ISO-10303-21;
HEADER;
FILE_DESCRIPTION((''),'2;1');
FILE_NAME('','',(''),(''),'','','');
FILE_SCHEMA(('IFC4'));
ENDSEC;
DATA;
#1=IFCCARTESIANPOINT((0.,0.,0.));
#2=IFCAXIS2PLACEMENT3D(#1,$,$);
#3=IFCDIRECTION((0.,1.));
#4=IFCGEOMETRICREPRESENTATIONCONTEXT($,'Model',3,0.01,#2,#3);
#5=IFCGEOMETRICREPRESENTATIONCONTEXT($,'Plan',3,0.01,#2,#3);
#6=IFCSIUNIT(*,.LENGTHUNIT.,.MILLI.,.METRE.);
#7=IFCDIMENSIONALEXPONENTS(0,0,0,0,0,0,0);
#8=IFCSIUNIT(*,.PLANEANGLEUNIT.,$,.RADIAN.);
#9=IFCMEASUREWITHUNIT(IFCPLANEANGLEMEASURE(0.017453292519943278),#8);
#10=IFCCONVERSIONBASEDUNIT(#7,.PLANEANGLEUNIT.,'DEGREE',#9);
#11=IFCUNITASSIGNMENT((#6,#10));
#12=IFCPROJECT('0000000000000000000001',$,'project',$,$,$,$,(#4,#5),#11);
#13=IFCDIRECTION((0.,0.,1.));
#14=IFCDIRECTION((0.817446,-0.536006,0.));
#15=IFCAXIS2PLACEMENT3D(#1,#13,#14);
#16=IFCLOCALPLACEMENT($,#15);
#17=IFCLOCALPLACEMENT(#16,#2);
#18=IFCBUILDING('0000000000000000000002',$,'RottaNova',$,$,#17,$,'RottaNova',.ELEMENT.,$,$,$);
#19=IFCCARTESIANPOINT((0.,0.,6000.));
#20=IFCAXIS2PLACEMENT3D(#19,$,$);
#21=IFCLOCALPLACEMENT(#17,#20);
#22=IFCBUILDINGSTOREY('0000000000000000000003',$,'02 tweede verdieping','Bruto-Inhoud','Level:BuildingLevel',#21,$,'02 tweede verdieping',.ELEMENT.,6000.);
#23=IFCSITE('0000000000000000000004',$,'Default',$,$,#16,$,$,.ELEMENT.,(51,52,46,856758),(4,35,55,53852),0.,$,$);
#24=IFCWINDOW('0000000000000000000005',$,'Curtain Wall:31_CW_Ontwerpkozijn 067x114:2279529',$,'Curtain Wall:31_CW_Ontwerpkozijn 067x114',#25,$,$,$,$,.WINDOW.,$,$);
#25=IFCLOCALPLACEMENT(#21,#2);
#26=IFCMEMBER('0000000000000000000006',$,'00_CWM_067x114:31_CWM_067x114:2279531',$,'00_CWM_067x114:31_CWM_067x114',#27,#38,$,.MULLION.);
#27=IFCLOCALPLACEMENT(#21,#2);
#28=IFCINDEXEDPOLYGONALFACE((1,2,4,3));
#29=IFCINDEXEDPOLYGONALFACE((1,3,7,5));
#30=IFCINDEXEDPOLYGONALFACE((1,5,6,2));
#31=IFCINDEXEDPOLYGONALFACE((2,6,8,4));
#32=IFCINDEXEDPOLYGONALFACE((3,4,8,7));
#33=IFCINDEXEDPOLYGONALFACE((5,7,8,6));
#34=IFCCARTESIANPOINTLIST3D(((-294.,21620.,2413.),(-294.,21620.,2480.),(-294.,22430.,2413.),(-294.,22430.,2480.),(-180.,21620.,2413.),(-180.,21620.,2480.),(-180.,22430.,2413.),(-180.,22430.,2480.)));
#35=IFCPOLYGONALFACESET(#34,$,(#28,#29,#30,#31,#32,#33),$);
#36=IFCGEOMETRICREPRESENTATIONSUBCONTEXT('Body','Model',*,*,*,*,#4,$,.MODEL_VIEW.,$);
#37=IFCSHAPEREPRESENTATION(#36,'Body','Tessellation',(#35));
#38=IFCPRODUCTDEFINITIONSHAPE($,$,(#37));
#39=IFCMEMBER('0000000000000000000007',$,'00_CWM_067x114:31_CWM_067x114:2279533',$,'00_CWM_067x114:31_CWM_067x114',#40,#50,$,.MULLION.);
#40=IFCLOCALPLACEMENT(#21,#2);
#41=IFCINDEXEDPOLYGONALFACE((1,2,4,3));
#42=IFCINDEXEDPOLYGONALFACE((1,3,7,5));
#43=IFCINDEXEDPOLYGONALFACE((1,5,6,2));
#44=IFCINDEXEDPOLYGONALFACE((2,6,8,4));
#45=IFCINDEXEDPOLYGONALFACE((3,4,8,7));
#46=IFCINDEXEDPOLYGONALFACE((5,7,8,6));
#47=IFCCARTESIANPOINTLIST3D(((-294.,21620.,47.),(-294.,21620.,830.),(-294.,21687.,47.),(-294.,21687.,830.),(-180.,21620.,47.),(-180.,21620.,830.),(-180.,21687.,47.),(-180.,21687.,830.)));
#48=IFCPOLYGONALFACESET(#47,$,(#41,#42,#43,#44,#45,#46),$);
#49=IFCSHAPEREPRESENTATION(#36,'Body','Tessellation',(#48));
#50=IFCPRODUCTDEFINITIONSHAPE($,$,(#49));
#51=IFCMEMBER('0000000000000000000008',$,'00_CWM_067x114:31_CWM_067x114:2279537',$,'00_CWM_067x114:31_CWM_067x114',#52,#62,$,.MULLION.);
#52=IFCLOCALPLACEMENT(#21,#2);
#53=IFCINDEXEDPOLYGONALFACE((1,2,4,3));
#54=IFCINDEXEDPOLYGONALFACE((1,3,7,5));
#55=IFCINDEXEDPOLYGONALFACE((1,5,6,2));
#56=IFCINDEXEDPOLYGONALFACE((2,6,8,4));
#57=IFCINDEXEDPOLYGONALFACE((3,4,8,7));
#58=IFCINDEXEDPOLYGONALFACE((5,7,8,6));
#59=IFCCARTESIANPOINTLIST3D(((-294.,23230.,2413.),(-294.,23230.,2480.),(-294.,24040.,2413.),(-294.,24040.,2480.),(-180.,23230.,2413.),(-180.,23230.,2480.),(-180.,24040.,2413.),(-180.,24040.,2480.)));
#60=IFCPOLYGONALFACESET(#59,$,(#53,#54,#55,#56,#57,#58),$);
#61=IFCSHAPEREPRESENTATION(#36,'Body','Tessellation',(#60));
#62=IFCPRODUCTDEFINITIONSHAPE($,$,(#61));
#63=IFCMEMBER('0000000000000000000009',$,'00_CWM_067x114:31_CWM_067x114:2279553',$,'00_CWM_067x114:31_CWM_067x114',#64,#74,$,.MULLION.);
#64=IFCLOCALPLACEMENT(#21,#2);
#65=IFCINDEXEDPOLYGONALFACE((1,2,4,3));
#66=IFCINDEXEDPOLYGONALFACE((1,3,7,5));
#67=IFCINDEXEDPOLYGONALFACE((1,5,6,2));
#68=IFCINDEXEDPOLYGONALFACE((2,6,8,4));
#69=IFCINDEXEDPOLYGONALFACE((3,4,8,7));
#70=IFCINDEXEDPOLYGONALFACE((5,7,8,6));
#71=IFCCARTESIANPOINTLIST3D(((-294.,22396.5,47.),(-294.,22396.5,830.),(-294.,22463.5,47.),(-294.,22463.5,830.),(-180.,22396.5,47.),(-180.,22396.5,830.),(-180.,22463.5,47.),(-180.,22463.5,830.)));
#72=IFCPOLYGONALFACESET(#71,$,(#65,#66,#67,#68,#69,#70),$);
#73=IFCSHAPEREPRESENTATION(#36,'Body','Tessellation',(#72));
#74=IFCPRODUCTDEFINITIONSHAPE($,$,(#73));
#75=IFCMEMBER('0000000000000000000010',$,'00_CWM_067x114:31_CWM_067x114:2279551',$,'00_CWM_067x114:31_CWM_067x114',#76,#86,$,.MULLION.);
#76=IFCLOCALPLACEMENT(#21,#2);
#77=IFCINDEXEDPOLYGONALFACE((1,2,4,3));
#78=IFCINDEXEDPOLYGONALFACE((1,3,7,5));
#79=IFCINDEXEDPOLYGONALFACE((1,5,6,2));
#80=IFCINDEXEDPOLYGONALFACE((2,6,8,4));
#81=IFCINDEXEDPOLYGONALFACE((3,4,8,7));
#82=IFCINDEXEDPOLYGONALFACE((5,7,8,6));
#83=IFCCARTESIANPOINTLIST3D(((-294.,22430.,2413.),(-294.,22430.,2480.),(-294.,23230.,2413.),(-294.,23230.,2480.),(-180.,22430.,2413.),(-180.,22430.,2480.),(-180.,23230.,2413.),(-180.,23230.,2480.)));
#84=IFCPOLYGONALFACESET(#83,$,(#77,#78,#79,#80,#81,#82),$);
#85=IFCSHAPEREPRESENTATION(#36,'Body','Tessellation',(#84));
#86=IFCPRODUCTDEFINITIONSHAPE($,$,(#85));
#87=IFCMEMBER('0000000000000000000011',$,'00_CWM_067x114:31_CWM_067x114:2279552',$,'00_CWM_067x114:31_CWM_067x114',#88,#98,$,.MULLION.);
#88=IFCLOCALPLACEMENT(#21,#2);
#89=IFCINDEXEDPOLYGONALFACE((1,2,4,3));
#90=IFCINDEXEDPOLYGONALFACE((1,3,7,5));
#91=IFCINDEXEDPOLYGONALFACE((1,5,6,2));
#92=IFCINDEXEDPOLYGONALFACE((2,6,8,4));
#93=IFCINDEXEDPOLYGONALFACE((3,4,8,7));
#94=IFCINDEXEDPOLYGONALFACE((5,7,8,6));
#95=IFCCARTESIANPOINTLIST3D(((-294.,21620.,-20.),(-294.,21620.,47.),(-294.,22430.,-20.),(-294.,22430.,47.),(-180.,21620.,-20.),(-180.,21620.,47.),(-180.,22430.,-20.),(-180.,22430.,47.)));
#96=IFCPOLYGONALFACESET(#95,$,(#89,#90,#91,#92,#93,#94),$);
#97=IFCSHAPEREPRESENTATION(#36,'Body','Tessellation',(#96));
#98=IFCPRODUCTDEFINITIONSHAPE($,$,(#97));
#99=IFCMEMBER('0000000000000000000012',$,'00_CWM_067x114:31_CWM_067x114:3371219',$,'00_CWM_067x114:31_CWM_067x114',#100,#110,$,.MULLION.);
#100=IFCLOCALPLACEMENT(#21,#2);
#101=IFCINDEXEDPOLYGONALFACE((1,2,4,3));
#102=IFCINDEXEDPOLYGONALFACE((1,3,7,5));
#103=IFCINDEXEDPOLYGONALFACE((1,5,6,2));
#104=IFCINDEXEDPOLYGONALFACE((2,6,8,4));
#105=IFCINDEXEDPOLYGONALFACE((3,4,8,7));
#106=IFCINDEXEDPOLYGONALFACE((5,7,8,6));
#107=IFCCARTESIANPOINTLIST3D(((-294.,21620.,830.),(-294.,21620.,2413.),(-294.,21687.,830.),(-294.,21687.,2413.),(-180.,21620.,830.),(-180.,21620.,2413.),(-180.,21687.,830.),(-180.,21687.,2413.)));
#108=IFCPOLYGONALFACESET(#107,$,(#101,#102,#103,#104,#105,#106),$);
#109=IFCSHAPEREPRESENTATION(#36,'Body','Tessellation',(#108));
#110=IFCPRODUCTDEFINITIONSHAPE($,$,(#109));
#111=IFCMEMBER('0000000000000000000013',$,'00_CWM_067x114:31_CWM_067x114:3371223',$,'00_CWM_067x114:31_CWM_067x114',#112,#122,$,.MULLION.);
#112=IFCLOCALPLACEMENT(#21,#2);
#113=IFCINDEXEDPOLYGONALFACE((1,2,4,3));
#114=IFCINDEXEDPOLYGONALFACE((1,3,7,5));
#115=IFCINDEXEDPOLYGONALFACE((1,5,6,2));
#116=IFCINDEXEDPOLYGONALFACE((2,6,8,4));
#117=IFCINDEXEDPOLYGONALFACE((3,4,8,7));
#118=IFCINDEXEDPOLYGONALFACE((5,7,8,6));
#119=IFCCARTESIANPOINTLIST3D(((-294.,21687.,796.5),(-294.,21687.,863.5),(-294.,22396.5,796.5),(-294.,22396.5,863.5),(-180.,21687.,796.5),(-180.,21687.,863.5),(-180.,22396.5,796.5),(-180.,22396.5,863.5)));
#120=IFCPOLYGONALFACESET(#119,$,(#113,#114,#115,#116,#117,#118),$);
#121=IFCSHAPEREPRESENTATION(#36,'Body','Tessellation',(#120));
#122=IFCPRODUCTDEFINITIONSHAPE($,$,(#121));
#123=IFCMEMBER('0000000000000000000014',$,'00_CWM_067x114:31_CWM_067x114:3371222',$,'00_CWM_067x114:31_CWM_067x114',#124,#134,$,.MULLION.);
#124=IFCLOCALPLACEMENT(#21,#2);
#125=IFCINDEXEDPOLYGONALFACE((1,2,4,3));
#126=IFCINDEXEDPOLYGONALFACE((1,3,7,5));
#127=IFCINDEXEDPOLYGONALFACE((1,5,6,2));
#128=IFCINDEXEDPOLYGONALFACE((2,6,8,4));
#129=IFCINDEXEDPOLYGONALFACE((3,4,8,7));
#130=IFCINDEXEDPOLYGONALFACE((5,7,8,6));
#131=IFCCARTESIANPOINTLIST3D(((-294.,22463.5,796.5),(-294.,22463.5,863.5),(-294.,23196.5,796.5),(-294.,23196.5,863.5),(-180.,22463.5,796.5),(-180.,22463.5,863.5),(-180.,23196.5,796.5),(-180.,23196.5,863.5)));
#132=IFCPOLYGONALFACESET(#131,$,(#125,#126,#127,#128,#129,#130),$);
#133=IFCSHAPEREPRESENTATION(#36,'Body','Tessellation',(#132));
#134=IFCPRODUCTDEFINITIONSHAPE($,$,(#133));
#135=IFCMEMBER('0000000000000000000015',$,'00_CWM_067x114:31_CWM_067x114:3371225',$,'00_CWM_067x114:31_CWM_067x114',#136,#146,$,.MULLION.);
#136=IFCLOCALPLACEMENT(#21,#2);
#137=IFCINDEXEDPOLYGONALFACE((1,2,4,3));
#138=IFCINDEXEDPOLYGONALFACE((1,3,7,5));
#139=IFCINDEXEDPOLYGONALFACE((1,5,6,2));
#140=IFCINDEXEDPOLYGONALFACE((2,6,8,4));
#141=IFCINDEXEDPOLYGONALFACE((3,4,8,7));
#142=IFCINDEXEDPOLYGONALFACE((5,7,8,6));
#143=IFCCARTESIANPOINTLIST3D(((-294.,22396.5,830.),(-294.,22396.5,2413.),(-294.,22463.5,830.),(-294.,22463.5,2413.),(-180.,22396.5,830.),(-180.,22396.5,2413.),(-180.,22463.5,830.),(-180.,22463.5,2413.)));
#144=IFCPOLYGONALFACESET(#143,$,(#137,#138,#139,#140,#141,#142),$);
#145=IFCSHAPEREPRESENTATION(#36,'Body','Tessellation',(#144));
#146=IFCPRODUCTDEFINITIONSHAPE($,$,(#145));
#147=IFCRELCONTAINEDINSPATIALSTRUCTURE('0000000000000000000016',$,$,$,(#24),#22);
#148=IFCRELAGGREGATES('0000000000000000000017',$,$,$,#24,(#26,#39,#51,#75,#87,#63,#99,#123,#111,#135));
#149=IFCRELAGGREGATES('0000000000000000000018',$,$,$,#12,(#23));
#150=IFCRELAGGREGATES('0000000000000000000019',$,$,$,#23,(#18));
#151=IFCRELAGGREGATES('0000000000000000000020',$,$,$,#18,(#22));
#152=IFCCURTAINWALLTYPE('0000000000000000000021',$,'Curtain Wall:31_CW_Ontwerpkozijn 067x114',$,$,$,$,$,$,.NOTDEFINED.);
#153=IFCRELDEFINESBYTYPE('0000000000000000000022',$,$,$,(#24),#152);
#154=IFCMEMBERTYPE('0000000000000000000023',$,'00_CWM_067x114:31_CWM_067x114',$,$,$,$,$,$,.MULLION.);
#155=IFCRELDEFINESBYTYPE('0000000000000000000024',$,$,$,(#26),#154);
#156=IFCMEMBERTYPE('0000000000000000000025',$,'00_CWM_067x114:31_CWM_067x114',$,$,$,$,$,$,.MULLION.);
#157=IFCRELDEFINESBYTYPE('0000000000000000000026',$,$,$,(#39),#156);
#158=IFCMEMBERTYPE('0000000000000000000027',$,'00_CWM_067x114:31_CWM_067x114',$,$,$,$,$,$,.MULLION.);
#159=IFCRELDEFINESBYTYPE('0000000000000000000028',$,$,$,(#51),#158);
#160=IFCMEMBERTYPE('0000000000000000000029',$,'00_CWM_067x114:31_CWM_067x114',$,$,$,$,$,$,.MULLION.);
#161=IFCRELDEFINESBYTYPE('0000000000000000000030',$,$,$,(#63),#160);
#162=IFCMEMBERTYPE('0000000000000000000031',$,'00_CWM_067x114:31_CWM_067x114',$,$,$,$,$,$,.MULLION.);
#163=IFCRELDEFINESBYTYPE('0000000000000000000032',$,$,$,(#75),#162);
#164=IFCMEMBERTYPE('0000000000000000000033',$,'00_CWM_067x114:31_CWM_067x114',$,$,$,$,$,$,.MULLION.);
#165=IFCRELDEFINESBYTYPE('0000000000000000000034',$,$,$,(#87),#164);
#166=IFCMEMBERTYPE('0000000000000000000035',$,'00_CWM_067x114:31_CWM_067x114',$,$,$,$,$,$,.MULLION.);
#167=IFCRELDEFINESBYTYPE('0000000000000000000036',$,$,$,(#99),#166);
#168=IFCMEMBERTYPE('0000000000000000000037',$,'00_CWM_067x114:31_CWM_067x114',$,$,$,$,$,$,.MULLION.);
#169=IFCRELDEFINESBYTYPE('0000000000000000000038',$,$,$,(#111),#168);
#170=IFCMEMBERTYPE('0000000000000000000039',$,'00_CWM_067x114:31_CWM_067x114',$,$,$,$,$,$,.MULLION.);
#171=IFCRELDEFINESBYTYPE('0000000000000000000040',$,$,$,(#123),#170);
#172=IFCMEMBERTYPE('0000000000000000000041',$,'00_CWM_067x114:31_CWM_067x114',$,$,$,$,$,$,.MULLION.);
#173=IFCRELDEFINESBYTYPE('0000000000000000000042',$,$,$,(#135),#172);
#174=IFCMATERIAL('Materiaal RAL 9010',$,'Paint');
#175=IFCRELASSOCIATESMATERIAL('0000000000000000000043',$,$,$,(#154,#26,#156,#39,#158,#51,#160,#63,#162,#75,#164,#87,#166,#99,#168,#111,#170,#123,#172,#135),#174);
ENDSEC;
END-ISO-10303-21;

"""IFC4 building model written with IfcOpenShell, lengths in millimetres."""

from ifc_helpers import new_model, entity, si_unit, converted_unit, direction, frame, origin, place, context, subcontext, project, spatial, indexed_curve, outline, extrude, source, transform, mapped, material, type_object, type_shapes, element, aggregate, save


model = new_model("IFC4")

# Units and contexts
model_context = context("Model", 3, precision=0.01, world=origin(), true_north=direction((0.0, 1.0)))
plan_context = context("Plan", 3, precision=0.01, world=origin(), true_north=direction((0.0, 1.0)))
body_context = subcontext(model_context, "Body", "Model", "MODEL_VIEW")
ifc_project = project(units=[si_unit("LENGTHUNIT", "METRE", prefix="MILLI"), converted_unit("PLANEANGLEUNIT", "DEGREE", entity("IfcPlaneAngleMeasure", 0.017453292519943278), si_unit("PLANEANGLEUNIT", "RADIAN"), dimensions=[0, 0, 0, 0, 0, 0, 0])], contexts=[model_context, plan_context])

# Site, building, storey
site_placement = place(None, frame((0.0, 0.0, 0.0), z_axis=(0.0, 0.0, 1.0), x_axis=(0.817446, -0.536006, 0.0)))
site = spatial("IfcSite", under=ifc_project, at=site_placement, Name="Default", CompositionType="ELEMENT", RefLatitude=(51, 52, 46, 856758), RefLongitude=(4, 35, 55, 53852), RefElevation=0.0)
building_placement = place(site_placement, origin())
building = spatial("IfcBuilding", under=site, at=building_placement, Name="RottaNova", LongName="RottaNova", CompositionType="ELEMENT")
storey_placement = place(building_placement, frame((0.0, 0.0, 6000.0)))
storey = spatial("IfcBuildingStorey", under=building, at=storey_placement, Name="02 tweede verdieping", Description="Bruto-Inhoud", ObjectType="Level:BuildingLevel", LongName="02 tweede verdieping", CompositionType="ELEMENT", Elevation=6000.0)

# Window, members
curtain_wall_type = type_object("IfcCurtainWallType", Name="Curtain Wall:31_CW_Ontwerpkozijn 067x114", PredefinedType="NOTDEFINED")
window_1_placement = place(storey_placement, frame((0.0, 0.0, -6000.0)))
window_1 = element("IfcWindow", 1, at=window_1_placement, inside=storey, type_object=curtain_wall_type, Name="Curtain Wall:31_CW_Ontwerpkozijn 067x114:2279529", ObjectType="Curtain Wall:31_CW_Ontwerpkozijn 067x114", PredefinedType="WINDOW")
ifc_material_1 = material(Name="Materiaal RAL 9010", Category="Paint")
member_type_1 = type_object("IfcMemberType", Name="00_CWM_067x114:31_CWM_067x114", PredefinedType="MULLION", material=ifc_material_1)
shared_shape_1 = source(origin(), body_context, "Body", "SweptSolid", [
    extrude(outline(indexed_curve([(-33.5, -57.0), (33.5, -57.0), (33.5, 57.0), (-33.5, 57.0), (-33.5, -57.0)], self_intersect=False)), frame((-33.5, 57.0, -810.0), z_axis=(0.0, 0.0, 1.0), x_axis=(-1.0, 0.0, 0.0)), (0.0, 0.0, 1.0), 810.0),
])
type_shapes(member_type_1, [shared_shape_1])
member_1_placement = place(window_1_placement, frame((-180.0, 21620.0, 8480.0), z_axis=(0.0, -1.0, 0.0), x_axis=(0.0, 0.0, 1.0)))
member_1 = element("IfcMember", 2, at=member_1_placement, type_object=member_type_1, material=ifc_material_1, Name="00_CWM_067x114:31_CWM_067x114:2279531", ObjectType="00_CWM_067x114:31_CWM_067x114", PredefinedType="MULLION", context=body_context, shape_type="MappedRepresentation", body=[
    mapped(shared_shape_1, transform((0.0, 0.0, 0.0), scale=1.0)),
])
member_type_2 = type_object("IfcMemberType", Name="00_CWM_067x114:31_CWM_067x114", PredefinedType="MULLION", material=ifc_material_1)
shared_shape_2 = source(origin(), body_context, "Body", "SweptSolid", [
    extrude(outline(indexed_curve([(-33.5, -57.0), (33.5, -57.0), (33.5, 57.0), (-33.5, 57.0), (-33.5, -57.0)], self_intersect=False)), frame((-33.5, 57.0, -783.0), z_axis=(0.0, 0.0, 1.0), x_axis=(-1.0, 0.0, 0.0)), (0.0, 0.0, 1.0), 783.0),
])
type_shapes(member_type_2, [shared_shape_2])
member_2_placement = place(window_1_placement, frame((-180.0, 21620.0, 6047.0), z_axis=(0.0, 0.0, -1.0), x_axis=(0.0, -1.0, 0.0)))
member_2 = element("IfcMember", 3, at=member_2_placement, type_object=member_type_2, material=ifc_material_1, Name="00_CWM_067x114:31_CWM_067x114:2279533", ObjectType="00_CWM_067x114:31_CWM_067x114", PredefinedType="MULLION", context=body_context, shape_type="MappedRepresentation", body=[
    mapped(shared_shape_2, transform((0.0, 0.0, 0.0), scale=1.0)),
])
member_type_3 = type_object("IfcMemberType", Name="00_CWM_067x114:31_CWM_067x114", PredefinedType="MULLION", material=ifc_material_1)
shared_shape_3 = source(origin(), body_context, "Body", "SweptSolid", [
    extrude(outline(indexed_curve([(-33.5, -57.0), (33.5, -57.0), (33.5, 57.0), (-33.5, 57.0), (-33.5, -57.0)], self_intersect=False)), frame((-33.5, 57.0, -810.0), z_axis=(0.0, 0.0, 1.0), x_axis=(-1.0, 0.0, 0.0)), (0.0, 0.0, 1.0), 810.0),
])
type_shapes(member_type_3, [shared_shape_3])
member_3_placement = place(window_1_placement, frame((-180.0, 23230.0, 8480.0), z_axis=(0.0, -1.0, 0.0), x_axis=(0.0, 0.0, 1.0)))
member_3 = element("IfcMember", 4, at=member_3_placement, type_object=member_type_3, material=ifc_material_1, Name="00_CWM_067x114:31_CWM_067x114:2279537", ObjectType="00_CWM_067x114:31_CWM_067x114", PredefinedType="MULLION", context=body_context, shape_type="MappedRepresentation", body=[
    mapped(shared_shape_3, transform((0.0, 0.0, 0.0), scale=1.0)),
])
member_type_4 = type_object("IfcMemberType", Name="00_CWM_067x114:31_CWM_067x114", PredefinedType="MULLION", material=ifc_material_1)
shared_shape_4 = source(origin(), body_context, "Body", "SweptSolid", [
    extrude(outline(indexed_curve([(-33.5, -57.0), (33.5, -57.0), (33.5, 57.0), (-33.5, 57.0), (-33.5, -57.0)], self_intersect=False)), frame((0.0, 57.0, -783.0), z_axis=(0.0, 0.0, 1.0), x_axis=(-1.0, 0.0, 0.0)), (0.0, 0.0, 1.0), 783.0),
])
type_shapes(member_type_4, [shared_shape_4])
member_4_placement = place(window_1_placement, frame((-180.0, 22430.0, 6047.0), z_axis=(0.0, 0.0, -1.0), x_axis=(0.0, -1.0, 0.0)))
member_4 = element("IfcMember", 5, at=member_4_placement, type_object=member_type_4, material=ifc_material_1, Name="00_CWM_067x114:31_CWM_067x114:2279553", ObjectType="00_CWM_067x114:31_CWM_067x114", PredefinedType="MULLION", context=body_context, shape_type="MappedRepresentation", body=[
    mapped(shared_shape_4, transform((0.0, 0.0, 0.0), scale=1.0)),
])
member_type_5 = type_object("IfcMemberType", Name="00_CWM_067x114:31_CWM_067x114", PredefinedType="MULLION", material=ifc_material_1)
shared_shape_5 = source(origin(), body_context, "Body", "SweptSolid", [
    extrude(outline(indexed_curve([(-33.5, -57.0), (33.5, -57.0), (33.5, 57.0), (-33.5, 57.0), (-33.5, -57.0)], self_intersect=False)), frame((-33.5, 57.0, -800.0), z_axis=(0.0, 0.0, 1.0), x_axis=(-1.0, 0.0, 0.0)), (0.0, 0.0, 1.0), 800.0),
])
type_shapes(member_type_5, [shared_shape_5])
member_5_placement = place(window_1_placement, frame((-180.0, 22430.0, 8480.0), z_axis=(0.0, -1.0, 0.0), x_axis=(0.0, 0.0, 1.0)))
member_5 = element("IfcMember", 6, at=member_5_placement, type_object=member_type_5, material=ifc_material_1, Name="00_CWM_067x114:31_CWM_067x114:2279551", ObjectType="00_CWM_067x114:31_CWM_067x114", PredefinedType="MULLION", context=body_context, shape_type="MappedRepresentation", body=[
    mapped(shared_shape_5, transform((0.0, 0.0, 0.0), scale=1.0)),
])
member_type_6 = type_object("IfcMemberType", Name="00_CWM_067x114:31_CWM_067x114", PredefinedType="MULLION", material=ifc_material_1)
shared_shape_6 = source(origin(), body_context, "Body", "SweptSolid", [
    extrude(outline(indexed_curve([(-33.5, -57.0), (33.5, -57.0), (33.5, 57.0), (-33.5, 57.0), (-33.5, -57.0)], self_intersect=False)), frame((-33.5, 57.0, -810.0), z_axis=(0.0, 0.0, 1.0), x_axis=(-1.0, 0.0, 0.0)), (0.0, 0.0, 1.0), 810.0),
])
type_shapes(member_type_6, [shared_shape_6])
member_6_placement = place(window_1_placement, frame((-180.0, 22430.0, 5980.0), z_axis=(0.0, 1.0, 0.0), x_axis=(0.0, 0.0, -1.0)))
member_6 = element("IfcMember", 7, at=member_6_placement, type_object=member_type_6, material=ifc_material_1, Name="00_CWM_067x114:31_CWM_067x114:2279552", ObjectType="00_CWM_067x114:31_CWM_067x114", PredefinedType="MULLION", context=body_context, shape_type="MappedRepresentation", body=[
    mapped(shared_shape_6, transform((0.0, 0.0, 0.0), scale=1.0)),
])
member_type_7 = type_object("IfcMemberType", Name="00_CWM_067x114:31_CWM_067x114", PredefinedType="MULLION", material=ifc_material_1)
shared_shape_7 = source(origin(), body_context, "Body", "SweptSolid", [
    extrude(outline(indexed_curve([(-33.5, -57.0), (33.5, -57.0), (33.5, 57.0), (-33.5, 57.0), (-33.5, -57.0)], self_intersect=False)), frame((-33.5, 57.0, -1583.0), z_axis=(0.0, 0.0, 1.0), x_axis=(-1.0, 0.0, 0.0)), (0.0, 0.0, 1.0), 1583.0),
])
type_shapes(member_type_7, [shared_shape_7])
member_7_placement = place(window_1_placement, frame((-180.0, 21620.0, 6830.0), z_axis=(0.0, 0.0, -1.0), x_axis=(0.0, -1.0, 0.0)))
member_7 = element("IfcMember", 8, at=member_7_placement, type_object=member_type_7, material=ifc_material_1, Name="00_CWM_067x114:31_CWM_067x114:3371219", ObjectType="00_CWM_067x114:31_CWM_067x114", PredefinedType="MULLION", context=body_context, shape_type="MappedRepresentation", body=[
    mapped(shared_shape_7, transform((0.0, 0.0, 0.0), scale=1.0)),
])
member_type_8 = type_object("IfcMemberType", Name="00_CWM_067x114:31_CWM_067x114", PredefinedType="MULLION", material=ifc_material_1)
shared_shape_8 = source(origin(), body_context, "Body", "SweptSolid", [
    extrude(outline(indexed_curve([(-33.5, -57.0), (33.5, -57.0), (33.5, 57.0), (-33.5, 57.0), (-33.5, -57.0)], self_intersect=False)), frame((0.0, 57.0, -709.5), z_axis=(0.0, 0.0, 1.0), x_axis=(-1.0, 0.0, 0.0)), (0.0, 0.0, 1.0), 709.5),
])
type_shapes(member_type_8, [shared_shape_8])
member_8_placement = place(window_1_placement, frame((-180.0, 21687.0, 6830.0), z_axis=(0.0, -1.0, 0.0), x_axis=(0.0, 0.0, 1.0)))
member_8 = element("IfcMember", 9, at=member_8_placement, type_object=member_type_8, material=ifc_material_1, Name="00_CWM_067x114:31_CWM_067x114:3371223", ObjectType="00_CWM_067x114:31_CWM_067x114", PredefinedType="MULLION", context=body_context, shape_type="MappedRepresentation", body=[
    mapped(shared_shape_8, transform((0.0, 0.0, 0.0), scale=1.0)),
])
member_type_9 = type_object("IfcMemberType", Name="00_CWM_067x114:31_CWM_067x114", PredefinedType="MULLION", material=ifc_material_1)
shared_shape_9 = source(origin(), body_context, "Body", "SweptSolid", [
    extrude(outline(indexed_curve([(-33.5, -57.0), (33.5, -57.0), (33.5, 57.0), (-33.5, 57.0), (-33.5, -57.0)], self_intersect=False)), frame((0.0, 57.0, -733.0), z_axis=(0.0, 0.0, 1.0), x_axis=(-1.0, 0.0, 0.0)), (0.0, 0.0, 1.0), 733.0),
])
type_shapes(member_type_9, [shared_shape_9])
member_9_placement = place(window_1_placement, frame((-180.0, 22463.5, 6830.0), z_axis=(0.0, -1.0, 0.0), x_axis=(0.0, 0.0, 1.0)))
member_9 = element("IfcMember", 10, at=member_9_placement, type_object=member_type_9, material=ifc_material_1, Name="00_CWM_067x114:31_CWM_067x114:3371222", ObjectType="00_CWM_067x114:31_CWM_067x114", PredefinedType="MULLION", context=body_context, shape_type="MappedRepresentation", body=[
    mapped(shared_shape_9, transform((0.0, 0.0, 0.0), scale=1.0)),
])
member_type_10 = type_object("IfcMemberType", Name="00_CWM_067x114:31_CWM_067x114", PredefinedType="MULLION", material=ifc_material_1)
shared_shape_10 = source(origin(), body_context, "Body", "SweptSolid", [
    extrude(outline(indexed_curve([(-33.5, -57.0), (33.5, -57.0), (33.5, 57.0), (-33.5, 57.0), (-33.5, -57.0)], self_intersect=False)), frame((0.0, 57.0, -1583.0), z_axis=(0.0, 0.0, 1.0), x_axis=(-1.0, 0.0, 0.0)), (0.0, 0.0, 1.0), 1583.0),
])
type_shapes(member_type_10, [shared_shape_10])
member_10_placement = place(window_1_placement, frame((-180.0, 22430.0, 6830.0), z_axis=(0.0, 0.0, -1.0), x_axis=(0.0, -1.0, 0.0)))
member_10 = element("IfcMember", 11, at=member_10_placement, type_object=member_type_10, material=ifc_material_1, Name="00_CWM_067x114:31_CWM_067x114:3371225", ObjectType="00_CWM_067x114:31_CWM_067x114", PredefinedType="MULLION", context=body_context, shape_type="MappedRepresentation", body=[
    mapped(shared_shape_10, transform((0.0, 0.0, 0.0), scale=1.0)),
])

aggregate(window_1, [member_1, member_2, member_3, member_5, member_6, member_4, member_7, member_9, member_8, member_10])

save(model, "model.ifc")
